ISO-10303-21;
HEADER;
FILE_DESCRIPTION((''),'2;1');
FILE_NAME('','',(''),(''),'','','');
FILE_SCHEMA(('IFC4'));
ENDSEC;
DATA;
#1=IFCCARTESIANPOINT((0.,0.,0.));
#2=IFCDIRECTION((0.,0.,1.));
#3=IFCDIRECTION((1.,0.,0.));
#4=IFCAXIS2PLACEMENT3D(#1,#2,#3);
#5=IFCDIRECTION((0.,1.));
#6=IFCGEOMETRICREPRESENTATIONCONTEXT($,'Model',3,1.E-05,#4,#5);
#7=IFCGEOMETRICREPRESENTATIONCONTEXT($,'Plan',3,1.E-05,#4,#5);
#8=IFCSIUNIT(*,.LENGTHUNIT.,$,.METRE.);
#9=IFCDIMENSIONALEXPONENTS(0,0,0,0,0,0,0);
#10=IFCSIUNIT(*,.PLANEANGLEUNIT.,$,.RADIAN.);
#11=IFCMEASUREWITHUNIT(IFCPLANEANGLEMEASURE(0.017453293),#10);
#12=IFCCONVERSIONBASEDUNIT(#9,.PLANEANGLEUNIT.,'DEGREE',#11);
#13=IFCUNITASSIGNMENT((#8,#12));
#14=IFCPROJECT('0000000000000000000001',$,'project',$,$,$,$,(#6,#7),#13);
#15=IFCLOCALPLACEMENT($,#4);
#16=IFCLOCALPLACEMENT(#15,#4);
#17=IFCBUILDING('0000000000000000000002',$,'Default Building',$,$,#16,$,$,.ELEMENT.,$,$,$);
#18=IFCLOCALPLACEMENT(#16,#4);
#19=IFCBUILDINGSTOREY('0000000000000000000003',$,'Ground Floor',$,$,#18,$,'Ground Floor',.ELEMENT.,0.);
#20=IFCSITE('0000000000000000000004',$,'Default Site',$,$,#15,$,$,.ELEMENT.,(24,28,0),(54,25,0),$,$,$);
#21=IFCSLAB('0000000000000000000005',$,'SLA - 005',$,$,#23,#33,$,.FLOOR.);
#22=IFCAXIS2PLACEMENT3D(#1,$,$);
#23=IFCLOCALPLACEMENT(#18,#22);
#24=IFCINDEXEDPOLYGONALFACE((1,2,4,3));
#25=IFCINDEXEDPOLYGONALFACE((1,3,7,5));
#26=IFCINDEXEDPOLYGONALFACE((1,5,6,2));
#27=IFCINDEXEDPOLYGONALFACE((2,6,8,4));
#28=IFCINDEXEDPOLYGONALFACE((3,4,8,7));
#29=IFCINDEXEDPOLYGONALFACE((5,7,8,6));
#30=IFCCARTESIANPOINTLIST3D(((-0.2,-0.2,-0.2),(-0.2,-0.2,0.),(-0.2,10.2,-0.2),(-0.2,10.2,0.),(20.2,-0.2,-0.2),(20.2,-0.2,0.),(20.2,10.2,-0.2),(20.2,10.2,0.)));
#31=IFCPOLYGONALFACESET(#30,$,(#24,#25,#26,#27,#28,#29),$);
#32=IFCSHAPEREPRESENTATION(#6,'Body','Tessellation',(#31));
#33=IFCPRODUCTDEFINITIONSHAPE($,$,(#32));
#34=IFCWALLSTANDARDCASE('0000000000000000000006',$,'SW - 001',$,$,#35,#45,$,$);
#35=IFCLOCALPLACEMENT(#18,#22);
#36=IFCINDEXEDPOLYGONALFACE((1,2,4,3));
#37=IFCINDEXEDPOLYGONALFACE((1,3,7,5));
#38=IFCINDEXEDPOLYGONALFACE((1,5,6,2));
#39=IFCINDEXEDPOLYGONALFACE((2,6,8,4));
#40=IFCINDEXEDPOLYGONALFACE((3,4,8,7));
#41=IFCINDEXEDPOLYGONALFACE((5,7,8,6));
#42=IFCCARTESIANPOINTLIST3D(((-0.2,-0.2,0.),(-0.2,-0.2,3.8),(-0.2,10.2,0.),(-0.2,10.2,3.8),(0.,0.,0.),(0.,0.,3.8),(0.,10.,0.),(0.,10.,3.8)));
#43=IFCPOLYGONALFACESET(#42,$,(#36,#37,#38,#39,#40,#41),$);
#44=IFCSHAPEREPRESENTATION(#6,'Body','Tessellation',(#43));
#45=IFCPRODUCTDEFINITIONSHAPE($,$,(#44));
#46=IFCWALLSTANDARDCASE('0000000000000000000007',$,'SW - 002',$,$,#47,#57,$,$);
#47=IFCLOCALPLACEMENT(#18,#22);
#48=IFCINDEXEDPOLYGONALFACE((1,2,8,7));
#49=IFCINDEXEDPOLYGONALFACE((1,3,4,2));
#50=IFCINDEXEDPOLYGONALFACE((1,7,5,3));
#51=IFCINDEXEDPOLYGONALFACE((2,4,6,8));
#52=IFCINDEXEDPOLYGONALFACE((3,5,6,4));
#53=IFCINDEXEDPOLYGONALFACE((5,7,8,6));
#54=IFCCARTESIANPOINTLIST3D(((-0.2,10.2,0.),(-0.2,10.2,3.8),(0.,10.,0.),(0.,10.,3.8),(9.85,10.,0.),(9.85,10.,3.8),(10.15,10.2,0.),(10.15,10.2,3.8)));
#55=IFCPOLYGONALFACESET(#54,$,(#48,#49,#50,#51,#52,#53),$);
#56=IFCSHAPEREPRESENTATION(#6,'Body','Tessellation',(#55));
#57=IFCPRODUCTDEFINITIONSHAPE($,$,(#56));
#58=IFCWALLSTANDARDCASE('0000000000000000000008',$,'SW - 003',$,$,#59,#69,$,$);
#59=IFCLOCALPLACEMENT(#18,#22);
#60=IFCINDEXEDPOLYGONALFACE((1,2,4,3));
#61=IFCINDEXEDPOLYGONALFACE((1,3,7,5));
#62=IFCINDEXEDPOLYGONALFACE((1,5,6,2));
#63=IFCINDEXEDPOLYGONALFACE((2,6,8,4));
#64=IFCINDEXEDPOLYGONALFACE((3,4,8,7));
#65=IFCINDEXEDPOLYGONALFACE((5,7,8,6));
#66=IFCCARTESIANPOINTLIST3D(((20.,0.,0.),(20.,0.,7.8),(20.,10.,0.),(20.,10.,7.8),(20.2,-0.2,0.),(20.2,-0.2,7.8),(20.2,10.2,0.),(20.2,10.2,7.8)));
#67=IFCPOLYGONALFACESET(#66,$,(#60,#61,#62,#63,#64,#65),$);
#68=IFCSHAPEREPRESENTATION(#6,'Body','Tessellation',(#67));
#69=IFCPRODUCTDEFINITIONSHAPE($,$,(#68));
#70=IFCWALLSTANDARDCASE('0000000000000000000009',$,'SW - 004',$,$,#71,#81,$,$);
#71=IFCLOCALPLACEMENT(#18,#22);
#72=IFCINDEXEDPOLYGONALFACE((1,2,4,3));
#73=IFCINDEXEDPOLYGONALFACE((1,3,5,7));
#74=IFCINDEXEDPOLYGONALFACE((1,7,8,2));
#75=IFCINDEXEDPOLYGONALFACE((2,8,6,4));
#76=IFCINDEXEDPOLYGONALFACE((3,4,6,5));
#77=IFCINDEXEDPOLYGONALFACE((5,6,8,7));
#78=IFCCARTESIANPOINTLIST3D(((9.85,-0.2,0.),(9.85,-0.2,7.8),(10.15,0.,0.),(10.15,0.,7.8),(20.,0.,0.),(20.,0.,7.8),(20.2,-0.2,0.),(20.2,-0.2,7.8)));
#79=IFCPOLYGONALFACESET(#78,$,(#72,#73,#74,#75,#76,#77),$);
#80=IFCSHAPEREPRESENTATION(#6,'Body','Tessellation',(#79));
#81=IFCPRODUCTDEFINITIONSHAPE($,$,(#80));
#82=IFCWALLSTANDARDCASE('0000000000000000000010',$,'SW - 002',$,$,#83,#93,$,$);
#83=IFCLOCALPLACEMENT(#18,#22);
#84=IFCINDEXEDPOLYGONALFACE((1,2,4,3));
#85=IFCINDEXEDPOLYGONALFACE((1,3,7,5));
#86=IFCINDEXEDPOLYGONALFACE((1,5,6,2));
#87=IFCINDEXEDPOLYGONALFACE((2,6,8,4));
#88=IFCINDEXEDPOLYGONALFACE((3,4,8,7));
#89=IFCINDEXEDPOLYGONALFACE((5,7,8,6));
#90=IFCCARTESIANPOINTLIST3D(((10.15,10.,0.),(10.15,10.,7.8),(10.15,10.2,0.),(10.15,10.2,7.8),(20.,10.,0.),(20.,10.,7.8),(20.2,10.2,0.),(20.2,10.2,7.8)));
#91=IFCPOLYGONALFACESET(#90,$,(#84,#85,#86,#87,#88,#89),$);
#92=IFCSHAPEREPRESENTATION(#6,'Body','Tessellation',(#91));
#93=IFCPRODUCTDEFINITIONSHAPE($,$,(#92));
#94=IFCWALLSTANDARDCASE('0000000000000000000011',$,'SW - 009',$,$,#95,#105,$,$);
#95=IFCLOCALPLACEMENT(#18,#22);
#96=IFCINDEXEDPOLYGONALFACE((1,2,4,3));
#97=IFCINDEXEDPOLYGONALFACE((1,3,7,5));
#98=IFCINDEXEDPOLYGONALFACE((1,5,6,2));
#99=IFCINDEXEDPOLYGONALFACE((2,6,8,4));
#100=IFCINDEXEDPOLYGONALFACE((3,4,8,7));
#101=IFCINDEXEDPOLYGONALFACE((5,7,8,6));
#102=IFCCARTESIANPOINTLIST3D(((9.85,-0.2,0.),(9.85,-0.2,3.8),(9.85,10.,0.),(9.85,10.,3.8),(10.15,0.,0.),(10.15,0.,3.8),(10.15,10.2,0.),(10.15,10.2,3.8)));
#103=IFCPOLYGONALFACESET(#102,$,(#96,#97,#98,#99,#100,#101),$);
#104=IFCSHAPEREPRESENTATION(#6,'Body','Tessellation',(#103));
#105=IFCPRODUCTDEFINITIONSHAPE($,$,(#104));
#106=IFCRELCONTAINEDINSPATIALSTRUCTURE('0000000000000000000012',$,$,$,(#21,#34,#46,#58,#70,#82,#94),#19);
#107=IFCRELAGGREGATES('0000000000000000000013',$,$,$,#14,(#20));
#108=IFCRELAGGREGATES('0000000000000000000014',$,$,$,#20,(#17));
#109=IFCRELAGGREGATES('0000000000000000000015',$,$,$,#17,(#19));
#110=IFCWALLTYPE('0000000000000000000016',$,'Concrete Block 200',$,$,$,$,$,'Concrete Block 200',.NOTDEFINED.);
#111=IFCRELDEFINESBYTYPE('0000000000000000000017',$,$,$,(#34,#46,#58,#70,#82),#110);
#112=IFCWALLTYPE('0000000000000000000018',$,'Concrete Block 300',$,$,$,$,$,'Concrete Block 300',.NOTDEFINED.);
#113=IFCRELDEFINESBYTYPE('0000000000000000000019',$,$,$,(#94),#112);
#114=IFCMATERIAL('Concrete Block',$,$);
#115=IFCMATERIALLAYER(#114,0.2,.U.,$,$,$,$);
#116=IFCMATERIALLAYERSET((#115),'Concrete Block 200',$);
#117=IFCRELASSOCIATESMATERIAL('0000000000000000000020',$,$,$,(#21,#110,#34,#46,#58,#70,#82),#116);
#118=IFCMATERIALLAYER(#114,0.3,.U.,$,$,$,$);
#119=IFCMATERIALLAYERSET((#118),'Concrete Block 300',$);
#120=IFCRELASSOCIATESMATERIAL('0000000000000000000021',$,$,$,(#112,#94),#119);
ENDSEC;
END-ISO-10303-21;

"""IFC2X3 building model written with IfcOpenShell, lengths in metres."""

from ifc_helpers import new_model, entity, si_unit, converted_unit, direction, frame, origin_with_axes, place, context, project, spatial, polyline, outline, extrude, material, layer, layer_set, layer_usage, type_object, element, save


model = new_model("IFC2X3")

# Units and contexts
model_context = context("Model", 3, precision=1e-05, world=origin_with_axes(), true_north=direction((0.0, 1.0)))
plan_context = context("Plan", 3, precision=1e-05, world=origin_with_axes(), true_north=direction((0.0, 1.0)))
ifc_project = project(units=[si_unit("LENGTHUNIT", "METRE"), converted_unit("PLANEANGLEUNIT", "DEGREE", entity("IfcPlaneAngleMeasure", 0.017453293), si_unit("PLANEANGLEUNIT", "RADIAN"), dimensions=[0, 0, 0, 0, 0, 0, 0])], contexts=[model_context, plan_context])

# Site, building, storey
site_placement = place(None, origin_with_axes())
site = spatial("IfcSite", under=ifc_project, at=site_placement, Name="Default Site", CompositionType="ELEMENT", RefLatitude=(24, 28, 0), RefLongitude=(54, 25, 0))
building_placement = place(site_placement, origin_with_axes())
building = spatial("IfcBuilding", under=site, at=building_placement, Name="Default Building", CompositionType="ELEMENT")
storey_placement = place(building_placement, origin_with_axes())
storey = spatial("IfcBuildingStorey", under=building, at=storey_placement, Name="Ground Floor", LongName="Ground Floor", CompositionType="ELEMENT", Elevation=0.0)

# Slab
ifc_material = material(Name="Concrete Block")
ifc_layer_1 = layer(ifc_material, 0.2, ventilated="UNKNOWN")
ifc_layer_set_1 = layer_set([ifc_layer_1], Name="Concrete Block 200")
ifc_layer_usage_1 = layer_usage(ifc_layer_set_1, "AXIS3", "NEGATIVE", 0.2)
slab_placement = place(storey_placement, frame((-0.2, 10.2, -0.2), z_axis=(0.0, 0.0, 1.0), x_axis=(1.0, 0.0, 0.0)))
element("IfcSlab", 1, at=slab_placement, inside=storey, material=ifc_layer_usage_1, Name="SLA - 005", PredefinedType="FLOOR", context=model_context, shape_type="SweptSolid", body=[
    extrude(outline(polyline([(0.0, 0.0), (20.4, 0.0), (20.4, -10.4), (0.0, -10.4), (0.0, 0.0)])), origin_with_axes(), (0.0, 0.0, 1.0), 0.2),
])

# Walls
ifc_layer_usage_2 = layer_usage(ifc_layer_set_1, "AXIS2", "POSITIVE", 0.0)
wall_type_1 = type_object("IfcWallType", Name="Concrete Block 200", ElementType="Concrete Block 200", PredefinedType="NOTDEFINED", material=ifc_layer_set_1)
wall_1_placement = place(storey_placement, frame((0.0, 0.0, 0.0), z_axis=(0.0, 0.0, 1.0), x_axis=(0.0, 1.0, 0.0)))
element("IfcWallStandardCase", 2, at=wall_1_placement, inside=storey, type_object=wall_type_1, material=ifc_layer_usage_2, Name="SW - 001", context=model_context, shape_type="SweptSolid", body=[
    extrude(outline(polyline([(0.0, 0.0), (10.0, 0.0), (10.2, 0.2), (-0.2, 0.2), (0.0, 0.0)])), origin_with_axes(), (0.0, 0.0, 1.0), 3.8),
])
ifc_layer_usage_3 = layer_usage(ifc_layer_set_1, "AXIS2", "POSITIVE", 0.0)
wall_2_placement = place(storey_placement, frame((0.0, 10.0, 0.0), z_axis=(0.0, 0.0, 1.0), x_axis=(1.0, 0.0, 0.0)))
element("IfcWallStandardCase", 3, at=wall_2_placement, inside=storey, type_object=wall_type_1, material=ifc_layer_usage_3, Name="SW - 002", context=model_context, shape_type="SweptSolid", body=[
    extrude(outline(polyline([(0.0, 0.0), (9.85, 0.0), (10.15, 0.2), (-0.2, 0.2), (0.0, 0.0)])), origin_with_axes(), (0.0, 0.0, 1.0), 3.8),
])
ifc_layer_usage_4 = layer_usage(ifc_layer_set_1, "AXIS2", "POSITIVE", 0.0)
wall_3_placement = place(storey_placement, frame((20.0, 10.0, 0.0), z_axis=(0.0, 0.0, 1.0), x_axis=(0.0, -1.0, 0.0)))
element("IfcWallStandardCase", 4, at=wall_3_placement, inside=storey, type_object=wall_type_1, material=ifc_layer_usage_4, Name="SW - 003", context=model_context, shape_type="SweptSolid", body=[
    extrude(outline(polyline([(0.0, 0.0), (10.0, 0.0), (10.2, 0.2), (-0.2, 0.2), (0.0, 0.0)])), origin_with_axes(), (0.0, 0.0, 1.0), 7.8),
])
ifc_layer_usage_5 = layer_usage(ifc_layer_set_1, "AXIS2", "POSITIVE", 0.0)
wall_4_placement = place(storey_placement, frame((20.0, 0.0, 0.0), z_axis=(0.0, 0.0, 1.0), x_axis=(-1.0, 0.0, 0.0)))
element("IfcWallStandardCase", 5, at=wall_4_placement, inside=storey, type_object=wall_type_1, material=ifc_layer_usage_5, Name="SW - 004", context=model_context, shape_type="SweptSolid", body=[
    extrude(outline(polyline([(0.0, 0.0), (9.85, 0.0), (10.15, 0.2), (-0.2, 0.2), (0.0, 0.0)])), origin_with_axes(), (0.0, 0.0, 1.0), 7.8),
])
ifc_layer_usage_6 = layer_usage(ifc_layer_set_1, "AXIS2", "POSITIVE", 0.0)
wall_5_placement = place(storey_placement, frame((10.15, 10.0, 0.0), z_axis=(0.0, 0.0, 1.0), x_axis=(1.0, 0.0, 0.0)))
element("IfcWallStandardCase", 6, at=wall_5_placement, inside=storey, type_object=wall_type_1, material=ifc_layer_usage_6, Name="SW - 002", context=model_context, shape_type="SweptSolid", body=[
    extrude(outline(polyline([(0.0, 0.0), (9.85, 0.0), (10.05, 0.2), (0.0, 0.2), (0.0, 0.0)])), origin_with_axes(), (0.0, 0.0, 1.0), 7.8),
])
ifc_layer_2 = layer(ifc_material, 0.3, ventilated="UNKNOWN")
ifc_layer_set_2 = layer_set([ifc_layer_2], Name="Concrete Block 300")
ifc_layer_usage_7 = layer_usage(ifc_layer_set_2, "AXIS2", "POSITIVE", 0.0)
wall_type_2 = type_object("IfcWallType", Name="Concrete Block 300", ElementType="Concrete Block 300", PredefinedType="NOTDEFINED", material=ifc_layer_set_2)
wall_6_placement = place(storey_placement, frame((10.15, 0.0, 0.0), z_axis=(0.0, 0.0, 1.0), x_axis=(0.0, 1.0, 0.0)))
element("IfcWallStandardCase", 7, at=wall_6_placement, inside=storey, type_object=wall_type_2, material=ifc_layer_usage_7, Name="SW - 009", context=model_context, shape_type="SweptSolid", body=[
    extrude(outline(polyline([(0.0, 0.0), (10.2, 0.0), (10.0, 0.3), (-0.2, 0.3), (0.0, 0.0)])), origin_with_axes(), (0.0, 0.0, 1.0), 3.8),
])

save(model, "model.ifc")
